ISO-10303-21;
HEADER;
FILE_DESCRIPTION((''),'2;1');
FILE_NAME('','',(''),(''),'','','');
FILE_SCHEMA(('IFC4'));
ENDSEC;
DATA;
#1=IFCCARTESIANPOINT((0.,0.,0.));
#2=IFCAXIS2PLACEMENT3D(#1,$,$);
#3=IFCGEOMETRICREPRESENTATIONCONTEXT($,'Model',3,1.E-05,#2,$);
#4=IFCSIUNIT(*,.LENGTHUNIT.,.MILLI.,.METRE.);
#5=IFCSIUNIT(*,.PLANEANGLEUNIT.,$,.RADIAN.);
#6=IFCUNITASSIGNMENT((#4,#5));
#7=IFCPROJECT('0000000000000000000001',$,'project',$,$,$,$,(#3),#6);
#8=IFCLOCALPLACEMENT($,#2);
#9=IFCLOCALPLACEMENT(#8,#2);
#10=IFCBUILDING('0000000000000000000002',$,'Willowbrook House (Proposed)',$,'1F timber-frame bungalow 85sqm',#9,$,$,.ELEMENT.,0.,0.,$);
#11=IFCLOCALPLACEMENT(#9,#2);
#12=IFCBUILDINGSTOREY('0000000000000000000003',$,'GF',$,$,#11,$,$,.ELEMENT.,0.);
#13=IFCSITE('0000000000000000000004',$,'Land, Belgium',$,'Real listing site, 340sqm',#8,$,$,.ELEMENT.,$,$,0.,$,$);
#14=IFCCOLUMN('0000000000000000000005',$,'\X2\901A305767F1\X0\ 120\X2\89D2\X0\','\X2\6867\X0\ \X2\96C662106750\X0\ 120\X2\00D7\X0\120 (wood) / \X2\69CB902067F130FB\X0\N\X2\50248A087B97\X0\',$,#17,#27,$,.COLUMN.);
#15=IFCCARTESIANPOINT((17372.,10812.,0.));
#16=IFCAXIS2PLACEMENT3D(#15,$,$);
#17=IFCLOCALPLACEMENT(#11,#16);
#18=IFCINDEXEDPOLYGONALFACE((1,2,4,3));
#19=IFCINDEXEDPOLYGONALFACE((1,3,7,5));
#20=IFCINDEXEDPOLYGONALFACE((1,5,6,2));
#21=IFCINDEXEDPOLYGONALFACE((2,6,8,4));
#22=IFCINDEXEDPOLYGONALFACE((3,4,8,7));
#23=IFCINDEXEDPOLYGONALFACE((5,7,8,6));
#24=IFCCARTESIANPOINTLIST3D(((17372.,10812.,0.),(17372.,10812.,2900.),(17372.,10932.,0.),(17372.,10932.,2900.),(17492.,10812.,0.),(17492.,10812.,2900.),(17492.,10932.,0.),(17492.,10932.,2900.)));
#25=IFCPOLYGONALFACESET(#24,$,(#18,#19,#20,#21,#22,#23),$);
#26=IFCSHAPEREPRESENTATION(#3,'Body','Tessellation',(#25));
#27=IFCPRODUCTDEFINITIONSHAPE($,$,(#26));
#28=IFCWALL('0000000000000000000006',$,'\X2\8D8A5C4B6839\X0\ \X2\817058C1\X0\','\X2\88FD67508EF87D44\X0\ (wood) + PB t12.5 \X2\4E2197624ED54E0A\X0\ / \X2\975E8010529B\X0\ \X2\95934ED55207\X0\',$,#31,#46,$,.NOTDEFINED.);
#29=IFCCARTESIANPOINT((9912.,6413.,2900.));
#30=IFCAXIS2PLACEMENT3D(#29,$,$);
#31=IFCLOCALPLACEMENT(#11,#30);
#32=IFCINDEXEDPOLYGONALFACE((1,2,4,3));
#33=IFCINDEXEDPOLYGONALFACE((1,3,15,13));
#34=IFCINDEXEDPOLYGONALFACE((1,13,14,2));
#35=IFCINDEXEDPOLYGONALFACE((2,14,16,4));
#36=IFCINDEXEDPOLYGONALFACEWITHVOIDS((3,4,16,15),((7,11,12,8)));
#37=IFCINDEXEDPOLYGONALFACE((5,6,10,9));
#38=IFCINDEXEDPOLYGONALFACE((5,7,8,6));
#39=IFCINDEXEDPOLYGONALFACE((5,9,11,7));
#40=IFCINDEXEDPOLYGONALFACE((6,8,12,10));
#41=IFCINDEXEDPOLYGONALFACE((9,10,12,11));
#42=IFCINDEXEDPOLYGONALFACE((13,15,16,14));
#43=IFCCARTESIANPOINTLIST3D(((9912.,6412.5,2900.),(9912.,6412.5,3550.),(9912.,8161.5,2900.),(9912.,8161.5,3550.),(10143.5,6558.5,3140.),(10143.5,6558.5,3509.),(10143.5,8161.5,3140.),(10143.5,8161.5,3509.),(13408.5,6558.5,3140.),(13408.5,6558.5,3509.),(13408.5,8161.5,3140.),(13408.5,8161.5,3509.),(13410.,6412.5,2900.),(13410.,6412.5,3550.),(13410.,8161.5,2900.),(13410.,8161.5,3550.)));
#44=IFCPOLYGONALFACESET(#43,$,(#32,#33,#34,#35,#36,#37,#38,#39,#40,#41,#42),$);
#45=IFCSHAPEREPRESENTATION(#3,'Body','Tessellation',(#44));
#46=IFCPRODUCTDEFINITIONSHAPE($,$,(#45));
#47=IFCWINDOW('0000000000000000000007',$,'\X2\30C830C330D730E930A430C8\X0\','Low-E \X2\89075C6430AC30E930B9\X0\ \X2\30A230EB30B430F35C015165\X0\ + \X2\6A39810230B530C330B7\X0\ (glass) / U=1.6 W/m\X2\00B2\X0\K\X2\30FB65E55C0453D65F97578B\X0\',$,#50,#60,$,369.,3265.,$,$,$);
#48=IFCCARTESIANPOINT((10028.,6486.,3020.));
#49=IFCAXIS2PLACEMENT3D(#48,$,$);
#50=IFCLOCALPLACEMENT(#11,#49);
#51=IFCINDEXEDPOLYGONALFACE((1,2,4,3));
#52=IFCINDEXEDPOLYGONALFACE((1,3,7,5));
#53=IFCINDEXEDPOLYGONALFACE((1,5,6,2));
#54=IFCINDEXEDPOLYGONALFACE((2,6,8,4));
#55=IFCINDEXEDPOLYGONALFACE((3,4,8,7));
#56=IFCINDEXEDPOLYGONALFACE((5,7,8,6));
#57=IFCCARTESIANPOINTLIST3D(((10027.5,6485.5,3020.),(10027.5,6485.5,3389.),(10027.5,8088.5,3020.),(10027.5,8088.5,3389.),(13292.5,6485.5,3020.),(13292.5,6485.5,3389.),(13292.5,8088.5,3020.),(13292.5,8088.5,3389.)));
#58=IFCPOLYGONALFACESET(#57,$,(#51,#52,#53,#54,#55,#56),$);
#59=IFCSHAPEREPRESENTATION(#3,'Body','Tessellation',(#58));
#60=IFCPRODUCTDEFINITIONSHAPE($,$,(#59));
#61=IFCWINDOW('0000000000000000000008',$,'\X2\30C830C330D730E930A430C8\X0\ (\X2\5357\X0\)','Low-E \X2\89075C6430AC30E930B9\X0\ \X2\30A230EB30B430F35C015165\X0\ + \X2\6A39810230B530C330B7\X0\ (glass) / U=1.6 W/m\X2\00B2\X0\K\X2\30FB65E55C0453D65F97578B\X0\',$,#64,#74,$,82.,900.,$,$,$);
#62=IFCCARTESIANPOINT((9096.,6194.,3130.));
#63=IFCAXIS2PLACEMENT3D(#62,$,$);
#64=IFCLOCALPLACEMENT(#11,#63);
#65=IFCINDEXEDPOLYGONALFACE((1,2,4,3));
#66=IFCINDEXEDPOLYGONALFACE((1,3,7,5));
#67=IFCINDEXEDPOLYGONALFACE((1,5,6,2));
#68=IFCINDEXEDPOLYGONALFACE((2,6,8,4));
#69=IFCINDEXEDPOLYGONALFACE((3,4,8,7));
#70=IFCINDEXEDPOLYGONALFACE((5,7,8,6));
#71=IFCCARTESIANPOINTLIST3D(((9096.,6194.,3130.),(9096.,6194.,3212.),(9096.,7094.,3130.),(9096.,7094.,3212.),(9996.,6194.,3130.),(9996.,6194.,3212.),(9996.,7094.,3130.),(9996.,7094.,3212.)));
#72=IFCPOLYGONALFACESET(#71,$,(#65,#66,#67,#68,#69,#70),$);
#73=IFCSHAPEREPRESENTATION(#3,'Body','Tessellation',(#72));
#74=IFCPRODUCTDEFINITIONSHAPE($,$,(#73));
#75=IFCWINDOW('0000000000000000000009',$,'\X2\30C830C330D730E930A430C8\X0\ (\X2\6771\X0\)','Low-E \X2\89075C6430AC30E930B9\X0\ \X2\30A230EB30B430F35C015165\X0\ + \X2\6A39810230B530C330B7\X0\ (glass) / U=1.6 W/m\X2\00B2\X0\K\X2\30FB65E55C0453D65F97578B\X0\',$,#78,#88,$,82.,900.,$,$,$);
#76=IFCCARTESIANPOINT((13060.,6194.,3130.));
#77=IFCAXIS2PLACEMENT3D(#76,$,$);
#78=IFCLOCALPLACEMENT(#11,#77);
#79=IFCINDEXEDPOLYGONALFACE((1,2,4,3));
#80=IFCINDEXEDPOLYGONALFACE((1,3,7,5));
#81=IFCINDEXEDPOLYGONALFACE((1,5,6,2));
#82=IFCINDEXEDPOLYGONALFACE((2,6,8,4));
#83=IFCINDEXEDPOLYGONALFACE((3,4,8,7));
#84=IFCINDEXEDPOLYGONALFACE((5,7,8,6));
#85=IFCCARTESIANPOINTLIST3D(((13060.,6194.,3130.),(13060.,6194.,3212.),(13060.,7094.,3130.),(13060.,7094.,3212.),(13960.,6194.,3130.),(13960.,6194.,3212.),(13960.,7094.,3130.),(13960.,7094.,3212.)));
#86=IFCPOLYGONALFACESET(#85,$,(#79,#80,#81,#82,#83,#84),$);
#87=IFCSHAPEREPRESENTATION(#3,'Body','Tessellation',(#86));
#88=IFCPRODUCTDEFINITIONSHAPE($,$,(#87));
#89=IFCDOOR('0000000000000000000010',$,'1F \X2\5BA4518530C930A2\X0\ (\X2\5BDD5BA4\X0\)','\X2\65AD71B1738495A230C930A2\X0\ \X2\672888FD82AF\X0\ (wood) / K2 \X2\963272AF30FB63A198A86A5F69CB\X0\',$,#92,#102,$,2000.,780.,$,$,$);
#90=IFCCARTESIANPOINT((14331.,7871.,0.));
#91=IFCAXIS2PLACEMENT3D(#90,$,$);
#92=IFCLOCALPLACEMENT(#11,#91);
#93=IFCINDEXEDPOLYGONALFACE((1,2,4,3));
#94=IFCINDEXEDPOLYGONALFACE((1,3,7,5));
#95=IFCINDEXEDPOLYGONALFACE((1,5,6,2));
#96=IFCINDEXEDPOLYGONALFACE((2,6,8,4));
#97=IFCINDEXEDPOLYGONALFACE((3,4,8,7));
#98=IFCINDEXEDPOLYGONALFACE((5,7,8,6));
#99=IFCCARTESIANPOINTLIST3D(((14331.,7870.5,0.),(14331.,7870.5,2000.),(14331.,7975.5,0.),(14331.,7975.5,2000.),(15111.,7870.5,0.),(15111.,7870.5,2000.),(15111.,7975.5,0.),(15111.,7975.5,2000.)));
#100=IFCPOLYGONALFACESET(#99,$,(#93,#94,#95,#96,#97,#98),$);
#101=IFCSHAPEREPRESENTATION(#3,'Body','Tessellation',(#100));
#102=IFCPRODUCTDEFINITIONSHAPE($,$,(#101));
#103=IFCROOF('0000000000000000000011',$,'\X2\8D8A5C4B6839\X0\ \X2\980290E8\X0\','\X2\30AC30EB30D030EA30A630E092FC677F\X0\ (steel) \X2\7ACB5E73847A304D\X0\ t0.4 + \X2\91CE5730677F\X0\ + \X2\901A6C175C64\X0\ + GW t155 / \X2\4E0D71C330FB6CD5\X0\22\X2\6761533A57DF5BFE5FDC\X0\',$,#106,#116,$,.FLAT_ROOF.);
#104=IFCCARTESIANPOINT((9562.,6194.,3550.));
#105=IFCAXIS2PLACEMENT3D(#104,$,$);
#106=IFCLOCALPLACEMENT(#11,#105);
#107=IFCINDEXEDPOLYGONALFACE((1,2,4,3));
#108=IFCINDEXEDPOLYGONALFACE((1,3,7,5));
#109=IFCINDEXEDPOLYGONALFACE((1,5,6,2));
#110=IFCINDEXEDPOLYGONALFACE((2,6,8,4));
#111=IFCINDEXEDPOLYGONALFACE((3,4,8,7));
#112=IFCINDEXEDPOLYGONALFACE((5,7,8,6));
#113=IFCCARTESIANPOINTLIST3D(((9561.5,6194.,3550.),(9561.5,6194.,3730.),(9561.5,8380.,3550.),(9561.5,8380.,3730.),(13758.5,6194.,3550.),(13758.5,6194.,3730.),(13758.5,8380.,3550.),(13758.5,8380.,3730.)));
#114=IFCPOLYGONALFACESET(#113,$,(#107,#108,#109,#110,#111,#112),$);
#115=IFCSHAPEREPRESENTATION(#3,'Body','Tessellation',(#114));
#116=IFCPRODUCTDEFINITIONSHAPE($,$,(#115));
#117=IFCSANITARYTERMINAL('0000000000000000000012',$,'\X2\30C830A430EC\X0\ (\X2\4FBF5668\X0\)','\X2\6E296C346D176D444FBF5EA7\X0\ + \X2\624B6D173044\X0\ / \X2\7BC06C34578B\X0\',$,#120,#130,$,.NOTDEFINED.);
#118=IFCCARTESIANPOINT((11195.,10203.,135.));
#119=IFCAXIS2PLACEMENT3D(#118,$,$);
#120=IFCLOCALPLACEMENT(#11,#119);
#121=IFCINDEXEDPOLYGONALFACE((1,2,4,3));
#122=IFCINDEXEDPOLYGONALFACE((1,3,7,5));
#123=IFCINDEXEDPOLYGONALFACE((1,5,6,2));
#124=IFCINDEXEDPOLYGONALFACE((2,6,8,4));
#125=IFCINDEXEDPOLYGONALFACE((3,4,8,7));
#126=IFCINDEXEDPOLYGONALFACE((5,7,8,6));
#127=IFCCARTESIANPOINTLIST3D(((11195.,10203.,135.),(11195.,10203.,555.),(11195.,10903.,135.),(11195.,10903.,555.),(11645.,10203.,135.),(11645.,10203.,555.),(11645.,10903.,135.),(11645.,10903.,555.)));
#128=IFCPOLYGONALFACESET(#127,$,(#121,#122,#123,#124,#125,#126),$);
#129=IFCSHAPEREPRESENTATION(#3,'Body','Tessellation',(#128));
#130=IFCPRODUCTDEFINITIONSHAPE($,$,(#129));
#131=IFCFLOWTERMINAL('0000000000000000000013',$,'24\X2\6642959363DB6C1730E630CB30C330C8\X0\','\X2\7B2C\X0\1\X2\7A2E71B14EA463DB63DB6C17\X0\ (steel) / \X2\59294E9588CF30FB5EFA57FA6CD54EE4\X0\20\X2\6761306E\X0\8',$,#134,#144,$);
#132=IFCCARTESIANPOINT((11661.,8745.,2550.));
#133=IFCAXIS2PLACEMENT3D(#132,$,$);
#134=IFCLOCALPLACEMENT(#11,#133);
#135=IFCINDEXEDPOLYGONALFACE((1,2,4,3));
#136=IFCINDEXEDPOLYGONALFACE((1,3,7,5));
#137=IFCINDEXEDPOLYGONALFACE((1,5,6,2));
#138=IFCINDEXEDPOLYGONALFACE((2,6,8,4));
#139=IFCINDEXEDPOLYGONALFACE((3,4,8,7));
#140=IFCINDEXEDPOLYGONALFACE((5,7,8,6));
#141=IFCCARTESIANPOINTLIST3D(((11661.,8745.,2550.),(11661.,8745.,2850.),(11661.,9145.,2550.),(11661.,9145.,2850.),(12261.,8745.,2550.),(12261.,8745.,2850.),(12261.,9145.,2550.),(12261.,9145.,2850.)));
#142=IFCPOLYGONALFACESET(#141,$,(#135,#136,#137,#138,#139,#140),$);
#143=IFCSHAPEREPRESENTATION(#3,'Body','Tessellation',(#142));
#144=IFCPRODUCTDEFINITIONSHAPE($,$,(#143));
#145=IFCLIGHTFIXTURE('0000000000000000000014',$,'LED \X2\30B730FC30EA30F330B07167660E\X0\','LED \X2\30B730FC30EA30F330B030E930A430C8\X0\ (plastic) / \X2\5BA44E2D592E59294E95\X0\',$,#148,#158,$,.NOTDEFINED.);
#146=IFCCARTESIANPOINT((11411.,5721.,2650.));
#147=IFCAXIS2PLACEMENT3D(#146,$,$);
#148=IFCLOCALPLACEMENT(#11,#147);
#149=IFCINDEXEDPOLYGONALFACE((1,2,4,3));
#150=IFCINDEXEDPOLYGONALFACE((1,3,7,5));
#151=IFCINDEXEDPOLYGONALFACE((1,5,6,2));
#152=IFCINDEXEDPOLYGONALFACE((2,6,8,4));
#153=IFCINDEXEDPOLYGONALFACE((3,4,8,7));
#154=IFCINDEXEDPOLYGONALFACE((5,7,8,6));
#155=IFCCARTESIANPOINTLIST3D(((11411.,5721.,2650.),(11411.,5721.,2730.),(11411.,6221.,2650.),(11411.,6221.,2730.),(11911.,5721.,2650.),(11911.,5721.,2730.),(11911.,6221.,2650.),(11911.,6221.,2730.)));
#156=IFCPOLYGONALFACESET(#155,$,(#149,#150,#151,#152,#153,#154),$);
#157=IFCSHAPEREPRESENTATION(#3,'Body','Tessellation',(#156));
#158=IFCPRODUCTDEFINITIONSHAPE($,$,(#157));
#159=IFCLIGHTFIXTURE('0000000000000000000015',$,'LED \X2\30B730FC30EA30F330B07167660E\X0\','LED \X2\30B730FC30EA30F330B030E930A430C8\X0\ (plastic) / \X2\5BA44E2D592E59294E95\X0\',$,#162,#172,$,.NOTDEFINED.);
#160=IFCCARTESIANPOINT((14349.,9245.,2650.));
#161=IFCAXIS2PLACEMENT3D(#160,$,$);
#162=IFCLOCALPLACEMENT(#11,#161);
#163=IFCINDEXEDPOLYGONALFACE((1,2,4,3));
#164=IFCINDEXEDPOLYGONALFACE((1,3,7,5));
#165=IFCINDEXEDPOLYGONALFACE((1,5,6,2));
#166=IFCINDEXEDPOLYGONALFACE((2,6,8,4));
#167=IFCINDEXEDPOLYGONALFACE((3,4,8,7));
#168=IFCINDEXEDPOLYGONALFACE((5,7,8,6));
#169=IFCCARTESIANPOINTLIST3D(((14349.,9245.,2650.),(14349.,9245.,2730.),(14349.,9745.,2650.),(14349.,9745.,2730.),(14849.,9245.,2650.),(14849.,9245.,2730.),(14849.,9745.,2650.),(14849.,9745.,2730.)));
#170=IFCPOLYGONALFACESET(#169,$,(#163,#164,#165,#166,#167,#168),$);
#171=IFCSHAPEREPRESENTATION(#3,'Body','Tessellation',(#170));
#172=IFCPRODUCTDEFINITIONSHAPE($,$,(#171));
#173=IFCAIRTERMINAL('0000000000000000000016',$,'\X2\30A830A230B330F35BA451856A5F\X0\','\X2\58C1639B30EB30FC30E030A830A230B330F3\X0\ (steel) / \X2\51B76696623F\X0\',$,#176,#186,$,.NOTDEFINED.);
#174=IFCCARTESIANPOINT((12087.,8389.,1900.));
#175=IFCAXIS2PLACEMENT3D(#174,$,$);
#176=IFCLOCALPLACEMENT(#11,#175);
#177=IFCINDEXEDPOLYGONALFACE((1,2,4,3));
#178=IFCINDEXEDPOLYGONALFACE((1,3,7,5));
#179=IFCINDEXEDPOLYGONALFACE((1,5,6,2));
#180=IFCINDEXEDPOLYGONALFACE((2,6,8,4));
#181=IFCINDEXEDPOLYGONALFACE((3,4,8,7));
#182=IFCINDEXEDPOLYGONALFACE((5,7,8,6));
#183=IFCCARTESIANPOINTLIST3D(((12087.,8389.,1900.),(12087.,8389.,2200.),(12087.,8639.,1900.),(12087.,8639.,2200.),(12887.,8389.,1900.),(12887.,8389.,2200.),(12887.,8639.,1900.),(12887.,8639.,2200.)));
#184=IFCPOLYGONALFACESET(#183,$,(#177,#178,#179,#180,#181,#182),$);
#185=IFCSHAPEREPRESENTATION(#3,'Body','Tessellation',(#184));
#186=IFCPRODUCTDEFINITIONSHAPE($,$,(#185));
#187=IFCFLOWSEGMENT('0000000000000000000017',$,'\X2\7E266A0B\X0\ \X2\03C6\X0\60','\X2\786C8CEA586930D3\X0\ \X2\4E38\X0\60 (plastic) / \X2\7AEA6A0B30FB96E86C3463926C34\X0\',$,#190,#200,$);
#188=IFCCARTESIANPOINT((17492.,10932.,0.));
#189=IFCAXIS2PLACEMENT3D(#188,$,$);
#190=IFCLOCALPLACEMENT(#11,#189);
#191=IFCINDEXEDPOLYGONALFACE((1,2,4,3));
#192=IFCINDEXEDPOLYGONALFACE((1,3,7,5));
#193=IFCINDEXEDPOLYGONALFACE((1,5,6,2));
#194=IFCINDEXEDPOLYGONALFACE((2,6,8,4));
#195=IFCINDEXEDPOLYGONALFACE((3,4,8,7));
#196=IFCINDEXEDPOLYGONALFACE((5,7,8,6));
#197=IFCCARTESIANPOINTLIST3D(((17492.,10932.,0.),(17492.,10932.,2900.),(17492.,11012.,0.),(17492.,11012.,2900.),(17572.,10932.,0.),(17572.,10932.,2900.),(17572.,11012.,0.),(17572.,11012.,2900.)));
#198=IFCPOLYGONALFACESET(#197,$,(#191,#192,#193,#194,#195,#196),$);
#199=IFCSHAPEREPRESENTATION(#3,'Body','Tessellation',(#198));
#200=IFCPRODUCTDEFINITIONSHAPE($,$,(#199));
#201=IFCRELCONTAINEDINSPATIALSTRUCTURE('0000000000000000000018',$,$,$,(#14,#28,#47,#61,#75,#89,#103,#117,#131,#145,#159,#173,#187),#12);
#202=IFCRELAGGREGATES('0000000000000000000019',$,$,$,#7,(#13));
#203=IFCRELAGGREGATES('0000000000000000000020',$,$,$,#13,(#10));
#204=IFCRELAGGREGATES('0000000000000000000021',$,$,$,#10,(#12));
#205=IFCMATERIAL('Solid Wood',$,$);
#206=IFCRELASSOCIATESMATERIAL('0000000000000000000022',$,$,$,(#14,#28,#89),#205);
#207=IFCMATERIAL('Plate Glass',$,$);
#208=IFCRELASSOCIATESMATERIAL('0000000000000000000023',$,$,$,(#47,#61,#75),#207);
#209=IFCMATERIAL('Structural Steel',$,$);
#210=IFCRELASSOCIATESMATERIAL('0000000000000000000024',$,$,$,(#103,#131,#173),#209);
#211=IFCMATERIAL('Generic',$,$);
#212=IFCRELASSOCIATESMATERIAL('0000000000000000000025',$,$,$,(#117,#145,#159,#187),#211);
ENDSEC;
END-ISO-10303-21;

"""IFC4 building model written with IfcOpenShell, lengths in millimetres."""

from ifc_helpers import new_model, si_unit, frame, frame_2d, origin, place, context, project, spatial, rectangle, extrude, material, element, fill, save


model = new_model("IFC4")

# Units and contexts
model_context = context("Model", 3, precision=1e-05, world=origin())
ifc_project = project(units=[si_unit("LENGTHUNIT", "METRE", prefix="MILLI"), si_unit("PLANEANGLEUNIT", "RADIAN")], contexts=[model_context])

# Site, building, storey
site_placement = place(None, origin())
site = spatial("IfcSite", under=ifc_project, at=site_placement, Name="Land, Belgium", ObjectType="Real listing site, 340sqm", CompositionType="ELEMENT", RefElevation=0.0)
building_placement = place(site_placement, origin())
building = spatial("IfcBuilding", under=site, at=building_placement, Name="Willowbrook House (Proposed)", ObjectType="1F timber-frame bungalow 85sqm", CompositionType="ELEMENT", ElevationOfRefHeight=0.0, ElevationOfTerrain=0.0)
storey_placement = place(building_placement, origin())
storey = spatial("IfcBuildingStorey", under=building, at=storey_placement, Name="GF", CompositionType="ELEMENT", Elevation=0.0)

# Column
ifc_material_1 = material(Name="Solid Wood")
column_1_placement = place(storey_placement, frame((17372.0, 10812.0, 0.0)))
element("IfcColumn", 1, at=column_1_placement, inside=storey, material=ifc_material_1, Name="通し柱 120角", Description="桧 集成材 120×120 (wood) / 構造柱・N値計算", PredefinedType="COLUMN", context=model_context, shape_type="SweptSolid", body=[
    extrude(rectangle(XDim=120.0, YDim=120.0, at=frame_2d((60.0, 60.0))), frame((17372.0, 10812.0, 0.0)), (0.0, 0.0, 1.0), 2900.0),
])

# Wall, openings, windows
wall_1_placement = place(storey_placement, frame((9912.0, 6413.0, 2900.0)))
wall_1 = element("IfcWall", 2, at=wall_1_placement, inside=storey, material=ifc_material_1, Name="越屋根 腰壁", Description="製材軸組 (wood) + PB t12.5 両面仕上 / 非耐力 間仕切", PredefinedType="NOTDEFINED", context=model_context, shape_type="SweptSolid", body=[
    extrude(rectangle(XDim=3498.0, YDim=1749.0, at=frame_2d((1749.0, 874.0))), frame((9912.0, 6413.0, 2900.0)), (0.0, 0.0, 1.0), 650.0),
])
opening_1_placement = place(storey_placement, frame((10028.0, 6486.0, 3020.0)))
opening_1 = element("IfcOpeningElement", 3, at=opening_1_placement, cuts=wall_1, PredefinedType="NOTDEFINED", context=model_context, shape_type="SweptSolid", body=[
    extrude(rectangle(XDim=3265.0, YDim=1603.0, at=frame_2d((1632.0, 801.0))), frame((10028.0, 6486.0, 3020.0)), (0.0, 0.0, 1.0), 369.0),
])
opening_2_placement = place(storey_placement, frame((9096.0, 6194.0, 3130.0)))
opening_2 = element("IfcOpeningElement", 4, at=opening_2_placement, cuts=wall_1, PredefinedType="NOTDEFINED", context=model_context, shape_type="SweptSolid", body=[
    extrude(rectangle(XDim=900.0, YDim=900.0, at=frame_2d((450.0, 450.0))), frame((9096.0, 6194.0, 3130.0)), (0.0, 0.0, 1.0), 82.0),
])
opening_3_placement = place(storey_placement, frame((13060.0, 6194.0, 3130.0)))
opening_3 = element("IfcOpeningElement", 5, at=opening_3_placement, cuts=wall_1, PredefinedType="NOTDEFINED", context=model_context, shape_type="SweptSolid", body=[
    extrude(rectangle(XDim=900.0, YDim=900.0, at=frame_2d((450.0, 450.0))), frame((13060.0, 6194.0, 3130.0)), (0.0, 0.0, 1.0), 82.0),
])
ifc_material_2 = material(Name="Plate Glass")
window_1_placement = place(storey_placement, frame((10028.0, 6486.0, 3020.0)))
window_1 = element("IfcWindow", 6, at=window_1_placement, inside=storey, material=ifc_material_2, Name="トップライト", Description="Low-E 複層ガラス アルゴン封入 + 樹脂サッシ (glass) / U=1.6 W/m²K・日射取得型", OverallHeight=369.0, OverallWidth=3265.0, context=model_context, shape_type="SweptSolid", body=[
    extrude(rectangle(XDim=3265.0, YDim=1603.0, at=frame_2d((1632.0, 801.0))), frame((10028.0, 6486.0, 3020.0)), (0.0, 0.0, 1.0), 369.0),
])
fill(opening_1, window_1)
window_2_placement = place(storey_placement, frame((9096.0, 6194.0, 3130.0)))
window_2 = element("IfcWindow", 7, at=window_2_placement, inside=storey, material=ifc_material_2, Name="トップライト (南)", Description="Low-E 複層ガラス アルゴン封入 + 樹脂サッシ (glass) / U=1.6 W/m²K・日射取得型", OverallHeight=82.0, OverallWidth=900.0, context=model_context, shape_type="SweptSolid", body=[
    extrude(rectangle(XDim=900.0, YDim=900.0, at=frame_2d((450.0, 450.0))), frame((9096.0, 6194.0, 3130.0)), (0.0, 0.0, 1.0), 82.0),
])
fill(opening_2, window_2)
window_3_placement = place(storey_placement, frame((13060.0, 6194.0, 3130.0)))
window_3 = element("IfcWindow", 8, at=window_3_placement, inside=storey, material=ifc_material_2, Name="トップライト (東)", Description="Low-E 複層ガラス アルゴン封入 + 樹脂サッシ (glass) / U=1.6 W/m²K・日射取得型", OverallHeight=82.0, OverallWidth=900.0, context=model_context, shape_type="SweptSolid", body=[
    extrude(rectangle(XDim=900.0, YDim=900.0, at=frame_2d((450.0, 450.0))), frame((13060.0, 6194.0, 3130.0)), (0.0, 0.0, 1.0), 82.0),
])
fill(opening_3, window_3)

# Door
door_placement = place(storey_placement, frame((14331.0, 7871.0, 0.0)))
element("IfcDoor", 9, at=door_placement, inside=storey, material=ifc_material_1, Name="1F 室内ドア (寝室)", Description="断熱玄関ドア 木製芯 (wood) / K2 防犯・採風機構", OverallHeight=2000.0, OverallWidth=780.0, context=model_context, shape_type="SweptSolid", body=[
    extrude(rectangle(XDim=780.0, YDim=105.0, at=frame_2d((390.0, 52.0))), frame((14331.0, 7871.0, 0.0)), (0.0, 0.0, 1.0), 2000.0),
])

# Roof
ifc_material_3 = material(Name="Structural Steel")
roof_placement = place(storey_placement, frame((9562.0, 6194.0, 3550.0)))
element("IfcRoof", 10, at=roof_placement, inside=storey, material=ifc_material_3, Name="越屋根 頂部", Description="ガルバリウム鋼板 (steel) 立平葺き t0.4 + 野地板 + 通気層 + GW t155 / 不燃・法22条区域対応", PredefinedType="FLAT_ROOF", context=model_context, shape_type="SweptSolid", body=[
    extrude(rectangle(XDim=4197.0, YDim=2186.0, at=frame_2d((2098.0, 1093.0))), frame((9562.0, 6194.0, 3550.0)), (0.0, 0.0, 1.0), 180.0),
])

# Sanitary terminal
ifc_material_4 = material(Name="Generic")
sanitary_terminal_placement = place(storey_placement, frame((11195.0, 10203.0, 135.0)))
element("IfcSanitaryTerminal", 11, at=sanitary_terminal_placement, inside=storey, material=ifc_material_4, Name="トイレ (便器)", Description="温水洗浄便座 + 手洗い / 節水型", PredefinedType="NOTDEFINED", context=model_context, shape_type="SweptSolid", body=[
    extrude(rectangle(XDim=450.0, YDim=700.0, at=frame_2d((225.0, 350.0))), frame((11195.0, 10203.0, 135.0)), (0.0, 0.0, 1.0), 420.0),
])

# Flow terminal
flow_terminal_placement = place(storey_placement, frame((11661.0, 8745.0, 2550.0)))
element("IfcFlowTerminal", 12, at=flow_terminal_placement, inside=storey, material=ifc_material_3, Name="24時間換気ユニット", Description="第1種熱交換換気 (steel) / 天井裏・建基法令20条の8", context=model_context, shape_type="SweptSolid", body=[
    extrude(rectangle(XDim=600.0, YDim=400.0, at=frame_2d((300.0, 200.0))), frame((11661.0, 8745.0, 2550.0)), (0.0, 0.0, 1.0), 300.0),
])

# Light fixtures
light_fixture_1_placement = place(storey_placement, frame((11411.0, 5721.0, 2650.0)))
element("IfcLightFixture", 13, at=light_fixture_1_placement, inside=storey, material=ifc_material_4, Name="LED シーリング照明", Description="LED シーリングライト (plastic) / 室中央天井", PredefinedType="NOTDEFINED", context=model_context, shape_type="SweptSolid", body=[
    extrude(rectangle(XDim=500.0, YDim=500.0, at=frame_2d((250.0, 250.0))), frame((11411.0, 5721.0, 2650.0)), (0.0, 0.0, 1.0), 80.0),
])
light_fixture_2_placement = place(storey_placement, frame((14349.0, 9245.0, 2650.0)))
element("IfcLightFixture", 14, at=light_fixture_2_placement, inside=storey, material=ifc_material_4, Name="LED シーリング照明", Description="LED シーリングライト (plastic) / 室中央天井", PredefinedType="NOTDEFINED", context=model_context, shape_type="SweptSolid", body=[
    extrude(rectangle(XDim=500.0, YDim=500.0, at=frame_2d((250.0, 250.0))), frame((14349.0, 9245.0, 2650.0)), (0.0, 0.0, 1.0), 80.0),
])

# Air terminal
air_terminal_placement = place(storey_placement, frame((12087.0, 8389.0, 1900.0)))
element("IfcAirTerminal", 15, at=air_terminal_placement, inside=storey, material=ifc_material_3, Name="エアコン室内機", Description="壁掛ルームエアコン (steel) / 冷暖房", PredefinedType="NOTDEFINED", context=model_context, shape_type="SweptSolid", body=[
    extrude(rectangle(XDim=800.0, YDim=250.0, at=frame_2d((400.0, 125.0))), frame((12087.0, 8389.0, 1900.0)), (0.0, 0.0, 1.0), 300.0),
])

# Flow segment
flow_segment_placement = place(storey_placement, frame((17492.0, 10932.0, 0.0)))
element("IfcFlowSegment", 16, at=flow_segment_placement, inside=storey, material=ifc_material_4, Name="縦樋 φ60", Description="硬質塩ビ 丸60 (plastic) / 竪樋・雨水排水", context=model_context, shape_type="SweptSolid", body=[
    extrude(rectangle(XDim=80.0, YDim=80.0, at=frame_2d((40.0, 40.0))), frame((17492.0, 10932.0, 0.0)), (0.0, 0.0, 1.0), 2900.0),
])

save(model, "model.ifc")
